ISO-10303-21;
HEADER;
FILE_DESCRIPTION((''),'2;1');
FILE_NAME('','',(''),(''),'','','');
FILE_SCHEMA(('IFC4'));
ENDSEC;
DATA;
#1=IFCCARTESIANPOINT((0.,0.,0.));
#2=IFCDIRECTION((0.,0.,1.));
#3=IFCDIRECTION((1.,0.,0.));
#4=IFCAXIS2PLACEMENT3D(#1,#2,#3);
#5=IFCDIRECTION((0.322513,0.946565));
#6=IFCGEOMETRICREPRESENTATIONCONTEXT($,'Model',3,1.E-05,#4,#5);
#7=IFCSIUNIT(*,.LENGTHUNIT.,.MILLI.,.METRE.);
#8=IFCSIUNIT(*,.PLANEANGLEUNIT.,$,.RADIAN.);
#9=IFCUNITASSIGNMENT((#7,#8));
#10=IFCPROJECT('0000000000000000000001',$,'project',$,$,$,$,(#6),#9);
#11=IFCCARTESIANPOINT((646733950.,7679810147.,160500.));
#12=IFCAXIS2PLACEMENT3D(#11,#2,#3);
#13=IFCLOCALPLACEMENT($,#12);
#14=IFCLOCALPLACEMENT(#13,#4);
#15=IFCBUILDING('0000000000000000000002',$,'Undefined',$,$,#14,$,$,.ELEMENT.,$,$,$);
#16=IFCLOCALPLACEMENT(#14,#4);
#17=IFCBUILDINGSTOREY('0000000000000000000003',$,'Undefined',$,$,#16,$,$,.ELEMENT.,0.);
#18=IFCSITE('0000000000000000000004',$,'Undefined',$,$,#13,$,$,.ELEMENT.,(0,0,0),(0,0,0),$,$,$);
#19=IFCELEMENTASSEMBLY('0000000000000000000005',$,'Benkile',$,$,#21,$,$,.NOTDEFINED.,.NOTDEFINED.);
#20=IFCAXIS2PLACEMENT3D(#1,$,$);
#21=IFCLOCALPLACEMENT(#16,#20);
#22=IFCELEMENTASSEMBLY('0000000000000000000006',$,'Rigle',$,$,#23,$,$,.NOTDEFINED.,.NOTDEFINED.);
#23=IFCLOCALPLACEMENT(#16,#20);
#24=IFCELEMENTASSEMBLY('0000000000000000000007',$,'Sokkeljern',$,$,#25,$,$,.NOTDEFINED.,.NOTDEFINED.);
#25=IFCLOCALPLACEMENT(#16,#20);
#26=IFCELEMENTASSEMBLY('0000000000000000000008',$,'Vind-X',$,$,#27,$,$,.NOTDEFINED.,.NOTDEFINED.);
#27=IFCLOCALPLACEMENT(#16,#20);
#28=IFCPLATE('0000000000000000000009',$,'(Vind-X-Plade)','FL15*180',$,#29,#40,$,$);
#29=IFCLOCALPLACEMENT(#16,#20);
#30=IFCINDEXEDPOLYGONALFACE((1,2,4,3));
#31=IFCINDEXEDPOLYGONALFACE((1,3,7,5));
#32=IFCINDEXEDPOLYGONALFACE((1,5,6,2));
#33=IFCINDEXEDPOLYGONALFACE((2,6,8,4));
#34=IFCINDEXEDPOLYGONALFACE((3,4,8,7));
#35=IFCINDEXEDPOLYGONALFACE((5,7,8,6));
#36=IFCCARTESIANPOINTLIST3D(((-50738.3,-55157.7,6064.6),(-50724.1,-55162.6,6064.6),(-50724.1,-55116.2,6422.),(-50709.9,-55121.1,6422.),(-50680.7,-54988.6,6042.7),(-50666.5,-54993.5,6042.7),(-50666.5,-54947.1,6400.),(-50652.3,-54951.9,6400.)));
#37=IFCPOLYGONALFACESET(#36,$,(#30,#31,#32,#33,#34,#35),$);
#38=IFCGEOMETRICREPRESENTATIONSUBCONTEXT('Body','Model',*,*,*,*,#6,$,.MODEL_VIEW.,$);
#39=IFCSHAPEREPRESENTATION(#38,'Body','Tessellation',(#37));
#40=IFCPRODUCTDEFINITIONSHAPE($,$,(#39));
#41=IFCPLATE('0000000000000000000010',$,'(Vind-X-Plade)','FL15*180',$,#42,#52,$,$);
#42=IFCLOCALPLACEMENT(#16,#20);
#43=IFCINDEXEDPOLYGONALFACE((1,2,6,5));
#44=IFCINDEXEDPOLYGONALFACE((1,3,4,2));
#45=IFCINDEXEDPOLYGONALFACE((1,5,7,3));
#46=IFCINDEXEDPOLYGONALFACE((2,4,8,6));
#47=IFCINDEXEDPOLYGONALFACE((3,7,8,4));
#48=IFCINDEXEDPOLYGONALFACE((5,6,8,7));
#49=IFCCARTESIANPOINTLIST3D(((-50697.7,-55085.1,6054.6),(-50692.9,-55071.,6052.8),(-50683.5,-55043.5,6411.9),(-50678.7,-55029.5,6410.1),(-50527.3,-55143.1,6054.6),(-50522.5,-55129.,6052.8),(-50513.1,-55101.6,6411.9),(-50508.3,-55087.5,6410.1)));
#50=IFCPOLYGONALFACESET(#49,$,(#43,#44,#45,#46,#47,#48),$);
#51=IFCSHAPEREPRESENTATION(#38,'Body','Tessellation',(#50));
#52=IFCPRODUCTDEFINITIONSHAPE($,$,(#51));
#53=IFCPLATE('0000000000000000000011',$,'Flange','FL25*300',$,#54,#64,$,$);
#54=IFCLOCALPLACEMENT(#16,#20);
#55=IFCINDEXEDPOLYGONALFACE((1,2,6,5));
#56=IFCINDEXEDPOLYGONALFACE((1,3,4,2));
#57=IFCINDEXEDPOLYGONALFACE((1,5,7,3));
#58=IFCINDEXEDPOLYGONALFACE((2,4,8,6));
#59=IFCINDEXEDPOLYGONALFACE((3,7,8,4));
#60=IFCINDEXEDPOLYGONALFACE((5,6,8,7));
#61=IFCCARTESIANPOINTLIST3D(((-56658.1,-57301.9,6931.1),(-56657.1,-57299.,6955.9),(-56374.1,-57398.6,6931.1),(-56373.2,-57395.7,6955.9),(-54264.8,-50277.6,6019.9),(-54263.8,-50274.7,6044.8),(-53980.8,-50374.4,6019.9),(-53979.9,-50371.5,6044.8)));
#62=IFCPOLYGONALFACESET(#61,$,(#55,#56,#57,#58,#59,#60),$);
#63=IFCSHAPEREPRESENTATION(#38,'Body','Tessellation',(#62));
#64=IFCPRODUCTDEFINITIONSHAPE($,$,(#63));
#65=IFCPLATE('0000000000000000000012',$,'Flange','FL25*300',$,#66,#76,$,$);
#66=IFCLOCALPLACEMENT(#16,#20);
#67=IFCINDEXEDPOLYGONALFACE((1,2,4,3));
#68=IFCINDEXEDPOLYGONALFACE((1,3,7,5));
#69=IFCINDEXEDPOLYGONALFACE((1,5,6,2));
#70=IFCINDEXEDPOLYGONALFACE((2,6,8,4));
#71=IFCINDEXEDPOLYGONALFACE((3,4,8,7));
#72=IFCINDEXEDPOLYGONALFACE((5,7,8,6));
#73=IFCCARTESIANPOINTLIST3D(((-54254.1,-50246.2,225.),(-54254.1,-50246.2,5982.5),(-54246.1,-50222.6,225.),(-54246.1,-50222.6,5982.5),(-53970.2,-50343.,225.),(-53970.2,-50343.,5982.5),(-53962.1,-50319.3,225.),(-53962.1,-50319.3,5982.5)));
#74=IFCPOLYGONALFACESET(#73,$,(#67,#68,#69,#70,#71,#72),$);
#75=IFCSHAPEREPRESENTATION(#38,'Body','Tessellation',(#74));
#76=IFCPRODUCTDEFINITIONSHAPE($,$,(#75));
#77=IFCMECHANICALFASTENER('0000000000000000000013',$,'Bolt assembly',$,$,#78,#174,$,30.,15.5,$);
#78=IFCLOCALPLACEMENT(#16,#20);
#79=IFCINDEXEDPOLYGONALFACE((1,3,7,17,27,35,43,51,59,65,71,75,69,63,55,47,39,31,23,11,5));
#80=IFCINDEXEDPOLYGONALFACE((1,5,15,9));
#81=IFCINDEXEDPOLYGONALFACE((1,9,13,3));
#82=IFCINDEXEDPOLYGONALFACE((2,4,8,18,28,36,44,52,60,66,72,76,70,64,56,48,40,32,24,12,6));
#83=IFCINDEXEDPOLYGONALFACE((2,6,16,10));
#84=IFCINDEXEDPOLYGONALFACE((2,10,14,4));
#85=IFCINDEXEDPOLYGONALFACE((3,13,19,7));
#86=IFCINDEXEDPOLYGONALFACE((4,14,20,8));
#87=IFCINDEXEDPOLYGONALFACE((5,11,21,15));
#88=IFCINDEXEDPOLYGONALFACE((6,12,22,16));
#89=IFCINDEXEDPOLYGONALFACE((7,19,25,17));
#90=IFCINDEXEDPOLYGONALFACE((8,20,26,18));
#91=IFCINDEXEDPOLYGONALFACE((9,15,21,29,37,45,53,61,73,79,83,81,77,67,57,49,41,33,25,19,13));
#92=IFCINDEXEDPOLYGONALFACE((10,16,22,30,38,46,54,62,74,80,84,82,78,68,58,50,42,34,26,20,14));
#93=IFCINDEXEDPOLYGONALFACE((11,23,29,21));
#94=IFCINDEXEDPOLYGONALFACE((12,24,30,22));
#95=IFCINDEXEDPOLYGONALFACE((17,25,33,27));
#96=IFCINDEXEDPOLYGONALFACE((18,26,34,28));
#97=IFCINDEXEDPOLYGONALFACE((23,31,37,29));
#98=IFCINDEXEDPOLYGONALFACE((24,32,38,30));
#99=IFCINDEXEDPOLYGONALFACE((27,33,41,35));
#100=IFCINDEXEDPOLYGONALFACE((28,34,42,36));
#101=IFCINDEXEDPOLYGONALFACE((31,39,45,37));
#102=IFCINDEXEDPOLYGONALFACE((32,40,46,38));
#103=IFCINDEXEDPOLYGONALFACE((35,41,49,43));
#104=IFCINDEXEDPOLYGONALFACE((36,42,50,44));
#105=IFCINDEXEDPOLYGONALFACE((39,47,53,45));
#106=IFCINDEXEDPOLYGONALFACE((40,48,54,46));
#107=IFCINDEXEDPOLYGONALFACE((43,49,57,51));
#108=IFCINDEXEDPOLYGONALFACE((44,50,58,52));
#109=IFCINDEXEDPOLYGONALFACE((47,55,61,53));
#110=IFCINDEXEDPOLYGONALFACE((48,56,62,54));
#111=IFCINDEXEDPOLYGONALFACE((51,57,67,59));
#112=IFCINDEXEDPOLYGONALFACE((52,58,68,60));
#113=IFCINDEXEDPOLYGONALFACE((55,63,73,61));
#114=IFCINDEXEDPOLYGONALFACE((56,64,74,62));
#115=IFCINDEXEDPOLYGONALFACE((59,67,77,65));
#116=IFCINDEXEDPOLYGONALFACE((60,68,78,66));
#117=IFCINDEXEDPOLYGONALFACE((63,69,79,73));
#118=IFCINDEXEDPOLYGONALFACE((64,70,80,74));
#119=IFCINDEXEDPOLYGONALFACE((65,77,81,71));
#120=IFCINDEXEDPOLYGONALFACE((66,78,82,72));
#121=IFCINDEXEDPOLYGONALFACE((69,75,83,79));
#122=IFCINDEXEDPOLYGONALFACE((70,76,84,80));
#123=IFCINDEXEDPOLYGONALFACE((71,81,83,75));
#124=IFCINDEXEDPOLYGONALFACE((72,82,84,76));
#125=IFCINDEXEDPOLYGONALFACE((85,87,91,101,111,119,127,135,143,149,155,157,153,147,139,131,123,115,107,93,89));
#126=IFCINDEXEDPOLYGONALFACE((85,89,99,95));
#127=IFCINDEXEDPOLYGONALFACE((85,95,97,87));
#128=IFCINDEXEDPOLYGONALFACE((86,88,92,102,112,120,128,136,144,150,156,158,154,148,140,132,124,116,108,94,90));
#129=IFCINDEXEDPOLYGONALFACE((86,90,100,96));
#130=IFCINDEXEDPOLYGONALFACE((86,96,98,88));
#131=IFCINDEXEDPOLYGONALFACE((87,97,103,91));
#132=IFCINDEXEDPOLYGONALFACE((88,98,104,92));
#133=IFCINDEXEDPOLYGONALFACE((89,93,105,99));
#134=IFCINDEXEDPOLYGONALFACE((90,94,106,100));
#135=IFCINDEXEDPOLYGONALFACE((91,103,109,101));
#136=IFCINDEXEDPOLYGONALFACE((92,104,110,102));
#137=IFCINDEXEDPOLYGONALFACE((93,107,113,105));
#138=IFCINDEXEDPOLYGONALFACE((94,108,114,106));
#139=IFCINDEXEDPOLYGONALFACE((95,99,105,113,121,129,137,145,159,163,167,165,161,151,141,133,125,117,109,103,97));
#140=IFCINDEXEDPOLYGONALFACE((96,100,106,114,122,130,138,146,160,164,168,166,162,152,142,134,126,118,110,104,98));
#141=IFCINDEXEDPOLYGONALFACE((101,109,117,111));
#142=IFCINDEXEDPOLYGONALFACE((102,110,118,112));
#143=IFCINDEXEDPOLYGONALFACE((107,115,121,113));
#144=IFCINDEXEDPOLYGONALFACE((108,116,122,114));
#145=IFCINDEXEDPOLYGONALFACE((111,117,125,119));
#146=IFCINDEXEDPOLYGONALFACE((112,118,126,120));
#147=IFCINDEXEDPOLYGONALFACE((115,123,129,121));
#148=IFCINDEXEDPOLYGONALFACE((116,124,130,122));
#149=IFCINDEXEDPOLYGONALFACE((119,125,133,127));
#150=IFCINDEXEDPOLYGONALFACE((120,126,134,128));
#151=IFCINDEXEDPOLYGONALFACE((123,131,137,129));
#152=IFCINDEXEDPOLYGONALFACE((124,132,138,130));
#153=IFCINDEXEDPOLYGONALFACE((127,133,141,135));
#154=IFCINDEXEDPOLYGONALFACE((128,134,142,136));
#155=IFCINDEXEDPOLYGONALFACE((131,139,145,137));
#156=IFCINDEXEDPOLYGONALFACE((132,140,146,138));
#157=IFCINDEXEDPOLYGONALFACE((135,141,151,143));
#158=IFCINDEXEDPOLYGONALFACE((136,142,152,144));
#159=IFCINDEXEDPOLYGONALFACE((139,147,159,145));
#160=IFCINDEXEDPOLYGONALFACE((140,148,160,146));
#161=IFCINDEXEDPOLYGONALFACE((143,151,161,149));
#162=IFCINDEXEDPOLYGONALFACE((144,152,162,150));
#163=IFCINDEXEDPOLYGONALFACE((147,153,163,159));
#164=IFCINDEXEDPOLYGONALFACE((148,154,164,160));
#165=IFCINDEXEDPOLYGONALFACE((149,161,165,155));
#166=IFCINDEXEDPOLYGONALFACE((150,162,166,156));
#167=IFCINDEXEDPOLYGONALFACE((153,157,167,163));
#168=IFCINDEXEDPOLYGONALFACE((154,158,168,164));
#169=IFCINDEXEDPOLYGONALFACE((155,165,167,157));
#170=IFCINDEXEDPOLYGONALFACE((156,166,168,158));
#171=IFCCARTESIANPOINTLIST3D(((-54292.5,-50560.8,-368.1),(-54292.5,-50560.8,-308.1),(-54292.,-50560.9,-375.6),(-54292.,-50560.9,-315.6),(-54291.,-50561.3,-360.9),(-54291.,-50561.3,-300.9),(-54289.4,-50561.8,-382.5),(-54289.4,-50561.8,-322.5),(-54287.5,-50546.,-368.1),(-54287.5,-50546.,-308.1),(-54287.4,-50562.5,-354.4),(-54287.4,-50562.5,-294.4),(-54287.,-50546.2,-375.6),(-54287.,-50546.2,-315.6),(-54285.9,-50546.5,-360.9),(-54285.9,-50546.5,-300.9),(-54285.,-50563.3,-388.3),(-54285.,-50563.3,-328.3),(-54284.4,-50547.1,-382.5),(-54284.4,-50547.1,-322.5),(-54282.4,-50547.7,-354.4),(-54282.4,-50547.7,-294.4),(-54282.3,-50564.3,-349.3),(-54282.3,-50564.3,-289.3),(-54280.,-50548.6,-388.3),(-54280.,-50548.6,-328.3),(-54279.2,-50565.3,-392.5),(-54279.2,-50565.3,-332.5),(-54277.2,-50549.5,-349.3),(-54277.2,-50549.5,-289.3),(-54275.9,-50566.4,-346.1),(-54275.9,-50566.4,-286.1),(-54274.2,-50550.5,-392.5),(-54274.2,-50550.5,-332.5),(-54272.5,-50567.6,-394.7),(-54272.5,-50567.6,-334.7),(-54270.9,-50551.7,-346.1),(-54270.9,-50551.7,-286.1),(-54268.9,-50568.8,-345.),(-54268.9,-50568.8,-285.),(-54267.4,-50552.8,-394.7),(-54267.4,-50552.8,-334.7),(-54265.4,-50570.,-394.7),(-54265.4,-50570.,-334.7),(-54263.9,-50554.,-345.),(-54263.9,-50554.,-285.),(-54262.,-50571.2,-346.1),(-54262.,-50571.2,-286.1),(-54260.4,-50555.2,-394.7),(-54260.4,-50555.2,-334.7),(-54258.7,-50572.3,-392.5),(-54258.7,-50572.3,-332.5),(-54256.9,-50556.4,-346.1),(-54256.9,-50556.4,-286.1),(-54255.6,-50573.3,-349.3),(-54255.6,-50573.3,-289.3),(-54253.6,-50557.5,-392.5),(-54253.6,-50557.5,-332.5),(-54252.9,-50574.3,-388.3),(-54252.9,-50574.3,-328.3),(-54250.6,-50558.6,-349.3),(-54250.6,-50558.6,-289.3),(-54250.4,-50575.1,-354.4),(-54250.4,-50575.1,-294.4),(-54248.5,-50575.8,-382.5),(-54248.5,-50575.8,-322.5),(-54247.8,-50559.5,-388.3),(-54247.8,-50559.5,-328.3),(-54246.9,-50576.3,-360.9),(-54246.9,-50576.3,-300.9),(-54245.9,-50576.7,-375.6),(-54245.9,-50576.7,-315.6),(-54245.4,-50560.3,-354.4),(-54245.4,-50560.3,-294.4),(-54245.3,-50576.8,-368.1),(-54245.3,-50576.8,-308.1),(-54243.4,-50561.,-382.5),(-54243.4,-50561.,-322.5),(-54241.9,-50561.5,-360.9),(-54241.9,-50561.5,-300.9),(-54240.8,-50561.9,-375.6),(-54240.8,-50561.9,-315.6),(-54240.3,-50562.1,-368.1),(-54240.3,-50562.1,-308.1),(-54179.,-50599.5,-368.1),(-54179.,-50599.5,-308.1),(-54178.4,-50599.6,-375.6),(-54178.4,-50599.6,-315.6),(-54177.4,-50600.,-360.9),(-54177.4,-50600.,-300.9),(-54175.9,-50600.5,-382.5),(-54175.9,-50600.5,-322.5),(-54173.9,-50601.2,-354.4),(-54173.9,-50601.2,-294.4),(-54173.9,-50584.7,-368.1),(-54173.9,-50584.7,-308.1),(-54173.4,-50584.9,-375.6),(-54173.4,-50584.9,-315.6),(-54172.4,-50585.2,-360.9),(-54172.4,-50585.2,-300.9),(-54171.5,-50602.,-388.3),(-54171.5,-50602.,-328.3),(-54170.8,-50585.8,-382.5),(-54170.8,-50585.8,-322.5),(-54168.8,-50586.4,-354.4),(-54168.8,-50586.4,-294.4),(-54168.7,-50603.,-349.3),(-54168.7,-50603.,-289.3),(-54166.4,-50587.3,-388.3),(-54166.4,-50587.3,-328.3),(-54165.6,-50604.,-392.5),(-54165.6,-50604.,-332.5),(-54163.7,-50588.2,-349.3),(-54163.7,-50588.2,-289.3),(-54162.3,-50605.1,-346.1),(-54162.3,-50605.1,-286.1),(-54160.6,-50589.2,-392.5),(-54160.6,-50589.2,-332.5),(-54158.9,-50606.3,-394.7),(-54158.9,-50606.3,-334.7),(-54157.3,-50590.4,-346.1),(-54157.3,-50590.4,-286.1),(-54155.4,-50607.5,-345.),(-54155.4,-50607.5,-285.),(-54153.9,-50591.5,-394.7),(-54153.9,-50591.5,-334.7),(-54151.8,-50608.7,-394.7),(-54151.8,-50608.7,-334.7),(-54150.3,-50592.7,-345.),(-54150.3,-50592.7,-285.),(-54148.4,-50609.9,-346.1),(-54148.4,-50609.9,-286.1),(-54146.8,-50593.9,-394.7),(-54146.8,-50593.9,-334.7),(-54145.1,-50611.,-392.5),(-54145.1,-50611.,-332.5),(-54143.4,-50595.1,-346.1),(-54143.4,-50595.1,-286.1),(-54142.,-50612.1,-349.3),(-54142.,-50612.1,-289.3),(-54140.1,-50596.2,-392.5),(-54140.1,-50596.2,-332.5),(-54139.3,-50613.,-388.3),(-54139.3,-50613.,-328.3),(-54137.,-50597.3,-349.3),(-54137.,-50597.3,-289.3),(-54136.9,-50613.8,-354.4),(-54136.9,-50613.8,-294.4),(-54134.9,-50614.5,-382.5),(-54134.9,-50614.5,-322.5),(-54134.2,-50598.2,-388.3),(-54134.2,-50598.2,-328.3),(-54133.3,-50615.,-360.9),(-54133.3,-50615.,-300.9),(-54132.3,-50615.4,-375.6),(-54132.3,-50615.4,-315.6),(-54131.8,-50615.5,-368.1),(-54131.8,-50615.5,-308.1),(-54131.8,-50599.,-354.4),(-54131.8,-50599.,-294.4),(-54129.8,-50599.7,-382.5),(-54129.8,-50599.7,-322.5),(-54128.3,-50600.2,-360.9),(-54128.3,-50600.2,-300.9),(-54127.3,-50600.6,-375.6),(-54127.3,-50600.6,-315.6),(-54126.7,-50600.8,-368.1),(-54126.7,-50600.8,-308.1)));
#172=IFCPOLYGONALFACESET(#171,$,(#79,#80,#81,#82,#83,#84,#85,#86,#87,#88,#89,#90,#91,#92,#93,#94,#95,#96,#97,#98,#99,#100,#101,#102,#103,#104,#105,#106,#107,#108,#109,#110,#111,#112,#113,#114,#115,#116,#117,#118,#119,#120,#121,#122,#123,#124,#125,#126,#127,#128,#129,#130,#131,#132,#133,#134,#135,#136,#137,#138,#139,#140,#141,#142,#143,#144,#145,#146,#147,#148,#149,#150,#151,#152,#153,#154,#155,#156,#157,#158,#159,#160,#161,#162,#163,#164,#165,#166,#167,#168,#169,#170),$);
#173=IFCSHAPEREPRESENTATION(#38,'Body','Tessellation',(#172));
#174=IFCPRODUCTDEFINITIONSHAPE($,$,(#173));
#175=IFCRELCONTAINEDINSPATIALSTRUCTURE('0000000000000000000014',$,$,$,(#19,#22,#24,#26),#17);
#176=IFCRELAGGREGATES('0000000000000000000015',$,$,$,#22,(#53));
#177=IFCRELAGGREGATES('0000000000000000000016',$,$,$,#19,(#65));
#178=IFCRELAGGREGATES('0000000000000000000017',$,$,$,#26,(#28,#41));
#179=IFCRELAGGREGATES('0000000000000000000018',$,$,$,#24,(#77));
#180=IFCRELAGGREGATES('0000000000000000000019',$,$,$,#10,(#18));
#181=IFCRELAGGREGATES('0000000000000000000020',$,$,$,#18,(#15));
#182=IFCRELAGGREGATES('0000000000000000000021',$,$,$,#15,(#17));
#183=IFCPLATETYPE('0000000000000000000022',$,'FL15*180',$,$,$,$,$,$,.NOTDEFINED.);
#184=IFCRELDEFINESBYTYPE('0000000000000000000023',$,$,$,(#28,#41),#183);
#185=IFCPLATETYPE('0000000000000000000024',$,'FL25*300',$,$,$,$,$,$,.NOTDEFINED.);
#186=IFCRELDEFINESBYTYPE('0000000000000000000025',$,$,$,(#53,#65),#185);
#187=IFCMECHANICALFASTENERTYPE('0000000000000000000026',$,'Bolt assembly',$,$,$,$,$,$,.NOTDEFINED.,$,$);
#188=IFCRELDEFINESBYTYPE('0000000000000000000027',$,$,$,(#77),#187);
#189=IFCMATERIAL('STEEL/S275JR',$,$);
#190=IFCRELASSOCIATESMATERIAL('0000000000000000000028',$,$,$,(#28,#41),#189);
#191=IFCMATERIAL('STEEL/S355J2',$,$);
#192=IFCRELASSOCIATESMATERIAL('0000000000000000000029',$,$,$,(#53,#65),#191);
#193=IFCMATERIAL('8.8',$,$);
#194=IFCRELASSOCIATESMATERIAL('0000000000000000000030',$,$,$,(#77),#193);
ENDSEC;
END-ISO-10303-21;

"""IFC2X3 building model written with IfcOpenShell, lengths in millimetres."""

from ifc_helpers import new_model, si_unit, direction, frame, origin_with_axes, origin_2d_with_axis, place, context, subcontext, project, spatial, polyline, circle, outline, extrude, clip, halfspace, source, transform, mapped, material, type_object, element, aggregate, save


model = new_model("IFC2X3")

# Units and contexts
model_context = context("Model", 3, precision=1e-05, world=origin_with_axes(), true_north=direction((0.322513, 0.946565)))
body_context = subcontext(model_context, "Body", "Model", "MODEL_VIEW")
ifc_project = project(units=[si_unit("LENGTHUNIT", "METRE", prefix="MILLI"), si_unit("PLANEANGLEUNIT", "RADIAN")], contexts=[model_context])

# Site, building, storey
site_placement = place(None, frame((646733950.0, 7679810147.0, 160500.0), z_axis=(0.0, 0.0, 1.0), x_axis=(1.0, 0.0, 0.0)))
site = spatial("IfcSite", under=ifc_project, at=site_placement, Name="Undefined", CompositionType="ELEMENT", RefLatitude=(0, 0, 0), RefLongitude=(0, 0, 0))
building_placement = place(site_placement, origin_with_axes())
building = spatial("IfcBuilding", under=site, at=building_placement, Name="Undefined", CompositionType="ELEMENT")
storey_placement = place(building_placement, origin_with_axes())
storey = spatial("IfcBuildingStorey", under=building, at=storey_placement, Name="Undefined", CompositionType="ELEMENT", Elevation=0.0)

# Element assemblies
ifc_material_1 = material(Name="STEEL/S355J2")
assembly_1_placement = place(storey_placement, origin_with_axes())
assembly_1 = element("IfcElementAssembly", 1, at=assembly_1_placement, inside=storey, Name="Benkile", AssemblyPlace="NOTDEFINED", PredefinedType="NOTDEFINED")
assembly_2_placement = place(storey_placement, origin_with_axes())
assembly_2 = element("IfcElementAssembly", 2, at=assembly_2_placement, inside=storey, Name="Rigle", AssemblyPlace="NOTDEFINED", PredefinedType="NOTDEFINED")

# Element assembly
assembly_3_placement = place(storey_placement, origin_with_axes())
assembly_3 = element("IfcElementAssembly", 3, at=assembly_3_placement, inside=storey, Name="Sokkeljern", AssemblyPlace="NOTDEFINED", PredefinedType="NOTDEFINED")

# Shared definitions
ifc_material_2 = material(Name="STEEL/S275JR")

# Element assembly, plates
plate_type_1 = type_object("IfcPlateType", Name="FL15*180", PredefinedType="NOTDEFINED")
assembly_4_placement = place(storey_placement, origin_with_axes())
assembly_4 = element("IfcElementAssembly", 4, at=assembly_4_placement, inside=storey, Name="Vind-X", AssemblyPlace="NOTDEFINED", PredefinedType="NOTDEFINED")
plate_1_placement = place(assembly_4_placement, frame((-50659.4, -54949.5, 6400.0), z_axis=(0.946565, -0.322513, 0.0), x_axis=(-0.320109, -0.93951, 0.121869)))
plate_1 = element("IfcPlate", 5, at=plate_1_placement, type_object=plate_type_1, material=ifc_material_2, Name="(Vind-X-Plade)", Description="FL15*180", context=body_context, shape_type="SweptSolid", body=[
    extrude(outline(polyline([(0.0, 0.0), (180.0, 0.0), (180.0, 360.0), (0.0, 360.0), (0.0, 0.0)])), frame((0.0, 0.0, -7.5), z_axis=(0.0, 0.0, 1.0), x_axis=(1.0, 0.0, 0.0)), (0.0, 0.0, 1.0), 15.0),
])
plate_2_placement = place(assembly_4_placement, frame((-50524.9, -55136.1, 6053.7), z_axis=(-0.320109, -0.93951, 0.121869), x_axis=(0.039304, 0.115357, 0.992546)))
plate_2 = element("IfcPlate", 6, at=plate_2_placement, type_object=plate_type_1, material=ifc_material_2, Name="(Vind-X-Plade)", Description="FL15*180", context=body_context, shape_type="SweptSolid", body=[
    extrude(outline(polyline([(0.0, 0.0), (360.0, 0.0), (360.0, 180.0), (0.0, 180.0), (0.0, 0.0)])), frame((0.0, 0.0, -7.5), z_axis=(0.0, 0.0, 1.0), x_axis=(1.0, 0.0, 0.0)), (0.0, 0.0, 1.0), 15.0),
])

# Plates
plate_type_2 = type_object("IfcPlateType", Name="FL25*300", PredefinedType="NOTDEFINED")
plate_3_placement = place(assembly_2_placement, frame((-54122.3, -50324.5, 6032.4), z_axis=(-0.039304, -0.115357, -0.992546), x_axis=(-0.320109, -0.93951, 0.121869)))
plate_3 = element("IfcPlate", 7, at=plate_3_placement, type_object=plate_type_2, material=ifc_material_1, Name="Flange", Description="FL25*300", context=body_context, shape_type="Clipping", body=[
    clip(extrude(outline(polyline([(0.0, -150.0), (0.0, 150.0), (7476.5, 150.0), (7476.5, -150.0), (0.0, -150.0)])), frame((0.0, 0.0, -12.5), z_axis=(0.0, 0.0, 1.0), x_axis=(1.0, 0.0, 0.0)), (0.0, 0.0, 1.0), 25.0), halfspace(frame((7476.5, 0.0, 287.5), z_axis=(1.0, 0.0, 0.0), x_axis=(0.0, 1.0, 0.0)), False)),
])
aggregate(assembly_2, [plate_3])
plate_4_placement = place(assembly_1_placement, frame((-54108.1, -50282.8, 200.0), z_axis=(-0.322513, -0.946565, 0.0), x_axis=(0.0, 0.0, 1.0)))
plate_4 = element("IfcPlate", 8, at=plate_4_placement, type_object=plate_type_2, material=ifc_material_1, Name="Flange", Description="FL25*300", context=body_context, shape_type="Clipping", body=[
    clip(extrude(outline(polyline([(25.0, -150.0), (25.0, 150.0), (5782.5, 150.0), (5782.5, -150.0), (25.0, -150.0)])), frame((0.0, 0.0, -12.5), z_axis=(0.0, 0.0, 1.0), x_axis=(1.0, 0.0, 0.0)), (0.0, 0.0, 1.0), 25.0), halfspace(frame((25.0, 0.0, 12.5), z_axis=(-1.0, 0.0, 0.0), x_axis=(0.0, 1.0, 0.0)), False)),
])

# Mechanical fastener
ifc_material_3 = material(Name="8.8")
mechanical_fastener_type = type_object("IfcMechanicalFastenerType", Name="Bolt assembly")
aggregate(assembly_1, [plate_4])
aggregate(assembly_4, [plate_1, plate_2])
shared_shape_1 = source(origin_with_axes(), body_context, "Body", "SweptSolid", [
    extrude(circle(Radius=25.0, at=origin_2d_with_axis()), frame((0.0, -15.5, 0.0), z_axis=(0.0, 1.0, 0.0), x_axis=(1.0, 0.0, 0.0)), (0.0, 0.0, 1.0), 15.6),
])
mechanical_fastener_1_placement = place(assembly_3_placement, frame((-54212.1, -50588.1, -370.0), z_axis=(0.946565, -0.322513, 0.0), x_axis=(0.0, 0.0, 1.0)))
mechanical_fastener_1 = element("IfcMechanicalFastener", 9, at=mechanical_fastener_1_placement, type_object=mechanical_fastener_type, material=ifc_material_3, Name="Bolt assembly", NominalDiameter=30.0, NominalLength=15.5, context=body_context, shape_type="MappedRepresentation", body=[
    mapped(shared_shape_1, transform((0.0, 0.0, -60.0))),
    mapped(shared_shape_1, transform((60.0, 0.0, -60.0))),
    mapped(shared_shape_1, transform((0.0, 0.0, 60.0))),
    mapped(shared_shape_1, transform((60.0, 0.0, 60.0))),
])
aggregate(assembly_3, [mechanical_fastener_1])

save(model, "model.ifc")
